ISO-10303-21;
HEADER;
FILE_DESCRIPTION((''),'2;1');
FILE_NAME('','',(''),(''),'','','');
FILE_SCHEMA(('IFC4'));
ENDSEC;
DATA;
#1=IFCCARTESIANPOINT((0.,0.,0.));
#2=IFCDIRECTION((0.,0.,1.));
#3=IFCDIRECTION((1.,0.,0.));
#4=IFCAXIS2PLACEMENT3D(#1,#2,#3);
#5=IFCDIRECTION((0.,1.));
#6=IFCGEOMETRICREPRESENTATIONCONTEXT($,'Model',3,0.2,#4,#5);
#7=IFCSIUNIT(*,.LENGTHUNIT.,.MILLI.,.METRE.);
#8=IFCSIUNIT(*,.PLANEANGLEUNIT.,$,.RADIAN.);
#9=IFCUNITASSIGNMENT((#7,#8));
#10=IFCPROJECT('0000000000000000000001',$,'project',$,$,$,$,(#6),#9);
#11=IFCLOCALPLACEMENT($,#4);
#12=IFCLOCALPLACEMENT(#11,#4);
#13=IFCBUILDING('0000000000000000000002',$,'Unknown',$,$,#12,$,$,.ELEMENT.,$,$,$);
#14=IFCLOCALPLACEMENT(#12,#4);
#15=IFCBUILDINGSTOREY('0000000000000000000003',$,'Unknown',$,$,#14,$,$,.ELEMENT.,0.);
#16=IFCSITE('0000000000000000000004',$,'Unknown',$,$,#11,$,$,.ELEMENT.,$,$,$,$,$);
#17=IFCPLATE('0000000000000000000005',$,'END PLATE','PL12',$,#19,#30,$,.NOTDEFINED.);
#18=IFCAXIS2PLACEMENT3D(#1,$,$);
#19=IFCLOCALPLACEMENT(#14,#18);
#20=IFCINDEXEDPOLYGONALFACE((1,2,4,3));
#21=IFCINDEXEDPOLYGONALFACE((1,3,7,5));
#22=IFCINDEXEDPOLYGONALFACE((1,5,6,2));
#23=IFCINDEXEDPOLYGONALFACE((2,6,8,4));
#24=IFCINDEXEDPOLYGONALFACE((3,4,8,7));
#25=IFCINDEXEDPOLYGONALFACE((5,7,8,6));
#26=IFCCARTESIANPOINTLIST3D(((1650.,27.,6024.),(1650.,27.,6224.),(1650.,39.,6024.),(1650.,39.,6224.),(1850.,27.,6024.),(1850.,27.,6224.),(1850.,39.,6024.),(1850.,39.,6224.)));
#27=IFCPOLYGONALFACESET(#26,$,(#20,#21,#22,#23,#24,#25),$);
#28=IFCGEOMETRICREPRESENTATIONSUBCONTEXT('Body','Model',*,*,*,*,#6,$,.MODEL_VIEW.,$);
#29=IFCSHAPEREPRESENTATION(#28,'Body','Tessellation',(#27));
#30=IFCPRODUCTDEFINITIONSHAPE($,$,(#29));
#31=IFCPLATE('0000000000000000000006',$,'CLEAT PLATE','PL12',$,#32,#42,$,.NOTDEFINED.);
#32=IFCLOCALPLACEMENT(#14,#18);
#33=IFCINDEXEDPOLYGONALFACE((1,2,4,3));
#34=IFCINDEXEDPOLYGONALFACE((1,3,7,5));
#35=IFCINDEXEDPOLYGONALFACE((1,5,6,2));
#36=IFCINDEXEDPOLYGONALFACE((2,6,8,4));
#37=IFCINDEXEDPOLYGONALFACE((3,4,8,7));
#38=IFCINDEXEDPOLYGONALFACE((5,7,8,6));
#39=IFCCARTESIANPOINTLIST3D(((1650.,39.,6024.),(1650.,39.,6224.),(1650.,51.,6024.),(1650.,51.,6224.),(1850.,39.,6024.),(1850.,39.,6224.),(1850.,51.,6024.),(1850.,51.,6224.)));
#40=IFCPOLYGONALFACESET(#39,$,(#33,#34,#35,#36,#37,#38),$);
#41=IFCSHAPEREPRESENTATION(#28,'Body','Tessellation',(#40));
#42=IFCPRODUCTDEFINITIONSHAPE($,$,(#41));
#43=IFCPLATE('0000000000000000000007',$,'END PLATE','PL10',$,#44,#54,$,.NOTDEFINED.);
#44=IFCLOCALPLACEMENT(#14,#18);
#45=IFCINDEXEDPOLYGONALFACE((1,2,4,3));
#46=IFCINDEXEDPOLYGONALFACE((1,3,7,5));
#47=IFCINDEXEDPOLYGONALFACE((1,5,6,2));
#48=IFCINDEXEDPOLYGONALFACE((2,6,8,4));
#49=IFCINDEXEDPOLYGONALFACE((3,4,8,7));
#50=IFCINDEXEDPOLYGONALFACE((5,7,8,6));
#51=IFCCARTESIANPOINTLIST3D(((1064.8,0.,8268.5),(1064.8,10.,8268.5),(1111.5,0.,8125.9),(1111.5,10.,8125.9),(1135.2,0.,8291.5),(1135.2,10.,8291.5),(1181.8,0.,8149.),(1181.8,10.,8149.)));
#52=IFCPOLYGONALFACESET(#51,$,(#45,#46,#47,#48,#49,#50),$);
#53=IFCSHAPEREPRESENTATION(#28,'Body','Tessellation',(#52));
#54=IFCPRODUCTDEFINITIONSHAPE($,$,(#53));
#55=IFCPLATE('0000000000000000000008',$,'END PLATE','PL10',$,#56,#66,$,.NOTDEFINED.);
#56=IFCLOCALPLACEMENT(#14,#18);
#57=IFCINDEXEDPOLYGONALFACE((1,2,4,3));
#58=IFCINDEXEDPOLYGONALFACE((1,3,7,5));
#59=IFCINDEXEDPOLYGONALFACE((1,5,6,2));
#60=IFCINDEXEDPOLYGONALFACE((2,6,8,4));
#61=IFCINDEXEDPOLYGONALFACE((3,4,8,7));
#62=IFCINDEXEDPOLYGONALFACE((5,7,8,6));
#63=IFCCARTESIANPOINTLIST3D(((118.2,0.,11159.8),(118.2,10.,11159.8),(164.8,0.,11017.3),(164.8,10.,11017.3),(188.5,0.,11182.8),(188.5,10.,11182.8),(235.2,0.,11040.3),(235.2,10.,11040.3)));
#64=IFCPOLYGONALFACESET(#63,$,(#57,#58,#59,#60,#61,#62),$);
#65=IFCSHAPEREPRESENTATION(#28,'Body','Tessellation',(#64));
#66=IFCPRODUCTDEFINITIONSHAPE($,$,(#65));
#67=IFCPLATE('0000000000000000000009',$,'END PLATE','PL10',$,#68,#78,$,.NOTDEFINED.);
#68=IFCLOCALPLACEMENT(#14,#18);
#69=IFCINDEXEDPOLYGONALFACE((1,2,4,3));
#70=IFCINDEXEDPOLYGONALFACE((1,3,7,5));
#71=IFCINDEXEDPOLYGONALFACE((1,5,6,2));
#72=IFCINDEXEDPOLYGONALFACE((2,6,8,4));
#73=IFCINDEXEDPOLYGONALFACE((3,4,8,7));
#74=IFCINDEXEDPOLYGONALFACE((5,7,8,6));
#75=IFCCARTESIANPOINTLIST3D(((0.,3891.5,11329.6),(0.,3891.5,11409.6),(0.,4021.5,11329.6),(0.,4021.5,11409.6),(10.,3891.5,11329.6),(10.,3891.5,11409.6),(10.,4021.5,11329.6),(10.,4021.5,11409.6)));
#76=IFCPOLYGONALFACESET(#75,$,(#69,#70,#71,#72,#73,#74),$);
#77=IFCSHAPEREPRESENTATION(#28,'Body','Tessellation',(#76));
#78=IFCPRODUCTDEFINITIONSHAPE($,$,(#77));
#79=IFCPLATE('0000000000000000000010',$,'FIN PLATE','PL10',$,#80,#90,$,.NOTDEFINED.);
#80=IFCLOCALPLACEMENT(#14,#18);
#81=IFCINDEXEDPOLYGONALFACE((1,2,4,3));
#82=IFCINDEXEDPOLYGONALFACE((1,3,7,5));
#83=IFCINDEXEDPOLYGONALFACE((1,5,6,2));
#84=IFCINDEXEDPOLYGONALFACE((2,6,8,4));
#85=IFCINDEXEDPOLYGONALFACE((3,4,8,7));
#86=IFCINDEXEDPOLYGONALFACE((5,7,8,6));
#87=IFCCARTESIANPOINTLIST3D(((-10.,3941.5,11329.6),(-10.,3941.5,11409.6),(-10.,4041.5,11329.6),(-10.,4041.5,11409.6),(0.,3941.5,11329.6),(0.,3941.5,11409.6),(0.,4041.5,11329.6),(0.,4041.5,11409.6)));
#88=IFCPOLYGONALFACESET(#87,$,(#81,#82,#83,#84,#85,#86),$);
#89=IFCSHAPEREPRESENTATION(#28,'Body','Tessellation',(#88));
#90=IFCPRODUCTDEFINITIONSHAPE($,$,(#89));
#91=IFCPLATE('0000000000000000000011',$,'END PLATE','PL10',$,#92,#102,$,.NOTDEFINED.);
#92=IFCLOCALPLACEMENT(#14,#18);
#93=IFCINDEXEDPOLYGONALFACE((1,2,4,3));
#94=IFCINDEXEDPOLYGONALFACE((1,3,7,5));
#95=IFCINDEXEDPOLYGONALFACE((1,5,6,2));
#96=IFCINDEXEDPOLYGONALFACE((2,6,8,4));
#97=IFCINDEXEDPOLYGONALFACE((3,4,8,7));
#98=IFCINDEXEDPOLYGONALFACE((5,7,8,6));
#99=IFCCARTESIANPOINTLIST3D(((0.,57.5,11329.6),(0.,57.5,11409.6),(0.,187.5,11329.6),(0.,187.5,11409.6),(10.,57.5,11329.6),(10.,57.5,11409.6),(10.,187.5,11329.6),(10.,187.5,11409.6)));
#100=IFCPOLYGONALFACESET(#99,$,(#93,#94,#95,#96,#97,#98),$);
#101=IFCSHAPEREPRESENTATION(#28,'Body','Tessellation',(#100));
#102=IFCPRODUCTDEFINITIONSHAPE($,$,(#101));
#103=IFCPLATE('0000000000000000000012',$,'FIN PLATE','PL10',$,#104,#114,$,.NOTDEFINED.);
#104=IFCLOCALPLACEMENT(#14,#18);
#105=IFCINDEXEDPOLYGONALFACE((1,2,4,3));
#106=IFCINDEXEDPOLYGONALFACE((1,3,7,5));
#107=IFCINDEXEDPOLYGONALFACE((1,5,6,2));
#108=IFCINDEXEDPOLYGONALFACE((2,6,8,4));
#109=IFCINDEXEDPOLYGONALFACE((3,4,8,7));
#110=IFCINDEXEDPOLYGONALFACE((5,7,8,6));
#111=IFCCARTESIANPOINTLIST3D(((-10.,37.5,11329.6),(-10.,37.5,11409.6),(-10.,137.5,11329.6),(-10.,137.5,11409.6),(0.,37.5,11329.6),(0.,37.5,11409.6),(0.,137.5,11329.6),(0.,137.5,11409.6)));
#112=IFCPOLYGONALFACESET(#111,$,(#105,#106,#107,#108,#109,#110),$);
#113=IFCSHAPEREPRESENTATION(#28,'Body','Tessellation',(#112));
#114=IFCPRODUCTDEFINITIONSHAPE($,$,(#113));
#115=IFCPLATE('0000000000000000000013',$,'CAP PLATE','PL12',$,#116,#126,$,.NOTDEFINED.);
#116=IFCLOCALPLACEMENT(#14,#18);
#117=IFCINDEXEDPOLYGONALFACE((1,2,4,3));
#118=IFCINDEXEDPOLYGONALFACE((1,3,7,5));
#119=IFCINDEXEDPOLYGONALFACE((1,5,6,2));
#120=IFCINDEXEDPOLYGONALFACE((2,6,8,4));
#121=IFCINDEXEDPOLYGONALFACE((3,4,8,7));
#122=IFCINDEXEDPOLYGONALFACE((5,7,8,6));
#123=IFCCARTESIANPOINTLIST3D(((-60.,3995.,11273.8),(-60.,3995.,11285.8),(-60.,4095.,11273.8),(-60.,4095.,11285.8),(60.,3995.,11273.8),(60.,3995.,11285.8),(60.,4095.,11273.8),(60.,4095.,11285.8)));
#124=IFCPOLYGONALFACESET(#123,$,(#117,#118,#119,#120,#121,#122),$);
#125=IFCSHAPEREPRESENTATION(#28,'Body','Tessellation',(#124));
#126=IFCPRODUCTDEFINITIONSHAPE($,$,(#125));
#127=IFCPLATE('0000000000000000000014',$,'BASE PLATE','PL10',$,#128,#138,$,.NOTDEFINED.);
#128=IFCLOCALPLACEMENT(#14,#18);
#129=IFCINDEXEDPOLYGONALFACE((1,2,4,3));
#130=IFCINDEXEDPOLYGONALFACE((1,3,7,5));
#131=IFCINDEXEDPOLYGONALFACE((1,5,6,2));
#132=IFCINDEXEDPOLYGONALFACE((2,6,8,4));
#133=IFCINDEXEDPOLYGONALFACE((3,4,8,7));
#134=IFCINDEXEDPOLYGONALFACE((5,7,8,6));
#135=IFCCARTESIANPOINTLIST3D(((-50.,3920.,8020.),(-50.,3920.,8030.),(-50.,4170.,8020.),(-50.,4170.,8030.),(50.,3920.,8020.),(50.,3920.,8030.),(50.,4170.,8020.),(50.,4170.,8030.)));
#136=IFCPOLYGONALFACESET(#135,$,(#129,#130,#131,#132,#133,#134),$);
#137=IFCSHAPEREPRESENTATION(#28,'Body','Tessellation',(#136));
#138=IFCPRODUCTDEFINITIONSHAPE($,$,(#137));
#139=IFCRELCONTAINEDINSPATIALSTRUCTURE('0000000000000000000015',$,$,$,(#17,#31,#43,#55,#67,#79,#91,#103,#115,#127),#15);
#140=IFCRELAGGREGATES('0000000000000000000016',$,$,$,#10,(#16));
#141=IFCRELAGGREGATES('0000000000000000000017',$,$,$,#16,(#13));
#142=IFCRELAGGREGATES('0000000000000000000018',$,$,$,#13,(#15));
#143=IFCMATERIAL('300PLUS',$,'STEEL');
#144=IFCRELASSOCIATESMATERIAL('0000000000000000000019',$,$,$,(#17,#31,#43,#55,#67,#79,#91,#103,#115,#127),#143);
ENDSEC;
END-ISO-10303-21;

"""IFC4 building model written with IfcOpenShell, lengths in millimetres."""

from ifc_helpers import new_model, si_unit, direction, frame, origin_with_axes, place, context, subcontext, project, spatial, line, indexed_curve, outline, extrude, material, element, save


model = new_model("IFC4")

# Units and contexts
model_context = context("Model", 3, precision=0.2, world=origin_with_axes(), true_north=direction((0.0, 1.0)))
body_context = subcontext(model_context, "Body", "Model", "MODEL_VIEW")
ifc_project = project(units=[si_unit("LENGTHUNIT", "METRE", prefix="MILLI"), si_unit("PLANEANGLEUNIT", "RADIAN")], contexts=[model_context])

# Site, building, storey
site_placement = place(None, origin_with_axes())
site = spatial("IfcSite", under=ifc_project, at=site_placement, Name="Unknown", CompositionType="ELEMENT")
building_placement = place(site_placement, origin_with_axes())
building = spatial("IfcBuilding", under=site, at=building_placement, Name="Unknown", CompositionType="ELEMENT")
storey_placement = place(building_placement, origin_with_axes())
storey = spatial("IfcBuildingStorey", under=building, at=storey_placement, Name="Unknown", CompositionType="ELEMENT", Elevation=0.0)

# Shared definitions
ifc_material_1 = material(Name="300PLUS", Category="STEEL")

# Plates
for number, where, z_axis, x_axis, name in (
    (1, (1650.0, 33.0, 6224.0), (0.0, 1.0, 0.0), (1.0, 0.0, 0.0), "END PLATE"),
    (2, (1650.0, 45.0, 6224.0), (0.0, 1.0, 0.0), (1.0, 0.0, 0.0), "CLEAT PLATE"),
):
    element("IfcPlate", number, at=place(storey_placement, frame(where, z_axis=z_axis, x_axis=x_axis)), inside=storey, material=ifc_material_1, Name=name, Description="PL12", PredefinedType="NOTDEFINED", context=body_context, shape_type="SolidModel", body=[
        extrude(outline(indexed_curve([(0.0, 0.0), (200.0, 0.0), (200.0, 200.0), (0.0, 200.0)], segments=[line(1, 2, 3, 4, 1)])), frame((0.0, 0.0, 6.0), z_axis=(0.0, 0.0, 1.0), x_axis=(1.0, 0.0, 0.0)), (0.0, 0.0, -1.0), 12.0),
    ])
plate_1_placement = place(storey_placement, frame((1064.8, 5.0, 8268.5), z_axis=(0.0, 1.0, 0.0), x_axis=(0.950557, 0.0, 0.310551)))
element("IfcPlate", 3, at=plate_1_placement, inside=storey, material=ifc_material_1, Name="END PLATE", Description="PL10", PredefinedType="NOTDEFINED", context=body_context, shape_type="SolidModel", body=[
    extrude(outline(indexed_curve([(0.0, 0.0), (74.1, 0.0), (74.1, 149.9), (0.1, 150.1)], segments=[line(1, 2, 3, 4, 1)])), frame((0.0, 0.0, 5.0), z_axis=(0.0, 0.0, 1.0), x_axis=(1.0, 0.0, 0.0)), (0.0, 0.0, -1.0), 10.0),
])
plate_2_placement = place(storey_placement, frame((118.2, 5.0, 11159.8), z_axis=(0.0, 1.0, 0.0), x_axis=(0.950426, 0.0, 0.31095)))
element("IfcPlate", 4, at=plate_2_placement, inside=storey, material=ifc_material_1, Name="END PLATE", Description="PL10", PredefinedType="NOTDEFINED", context=body_context, shape_type="SolidModel", body=[
    extrude(outline(indexed_curve([(0.0, 0.0), (74.0, 0.0), (74.0, 150.0), (0.0, 149.9)], segments=[line(1, 2, 3, 4, 1)])), frame((0.0, 0.0, 5.0), z_axis=(0.0, 0.0, 1.0), x_axis=(1.0, 0.0, 0.0)), (0.0, 0.0, -1.0), 10.0),
])
plate_3_placement = place(storey_placement, frame((5.0, 3891.5, 11329.6), z_axis=(1.0, 0.0, 0.0), x_axis=(0.0, 1.0, 0.0)))
element("IfcPlate", 5, at=plate_3_placement, inside=storey, material=ifc_material_1, Name="END PLATE", Description="PL10", PredefinedType="NOTDEFINED", context=body_context, shape_type="SolidModel", body=[
    extrude(outline(indexed_curve([(0.0, 0.0), (130.0, 0.0), (130.0, 80.0), (0.0, 80.0)], segments=[line(1, 2, 3, 4, 1)])), frame((0.0, 0.0, 5.0), z_axis=(0.0, 0.0, 1.0), x_axis=(1.0, 0.0, 0.0)), (0.0, 0.0, -1.0), 10.0),
])
plate_4_placement = place(storey_placement, frame((-5.0, 4041.5, 11329.6), z_axis=(-1.0, 0.0, 0.0), x_axis=(0.0, -1.0, 0.0)))
element("IfcPlate", 6, at=plate_4_placement, inside=storey, material=ifc_material_1, Name="FIN PLATE", Description="PL10", PredefinedType="NOTDEFINED", context=body_context, shape_type="SolidModel", body=[
    extrude(outline(indexed_curve([(0.0, 0.0), (100.0, 0.0), (100.0, 80.0), (0.0, 80.0)], segments=[line(1, 2, 3, 4, 1)])), frame((0.0, 0.0, 5.0), z_axis=(0.0, 0.0, 1.0), x_axis=(1.0, 0.0, 0.0)), (0.0, 0.0, -1.0), 10.0),
])
plate_5_placement = place(storey_placement, frame((5.0, 187.5, 11409.6), z_axis=(1.0, 0.0, 0.0), x_axis=(0.0, -1.0, 0.0)))
element("IfcPlate", 7, at=plate_5_placement, inside=storey, material=ifc_material_1, Name="END PLATE", Description="PL10", PredefinedType="NOTDEFINED", context=body_context, shape_type="SolidModel", body=[
    extrude(outline(indexed_curve([(0.0, 0.0), (130.0, 0.0), (130.0, 80.0), (0.0, 80.0)], segments=[line(1, 2, 3, 4, 1)])), frame((0.0, 0.0, 5.0), z_axis=(0.0, 0.0, 1.0), x_axis=(1.0, 0.0, 0.0)), (0.0, 0.0, -1.0), 10.0),
])
plate_6_placement = place(storey_placement, frame((-5.0, 37.5, 11409.6), z_axis=(-1.0, 0.0, 0.0), x_axis=(0.0, 1.0, 0.0)))
element("IfcPlate", 8, at=plate_6_placement, inside=storey, material=ifc_material_1, Name="FIN PLATE", Description="PL10", PredefinedType="NOTDEFINED", context=body_context, shape_type="SolidModel", body=[
    extrude(outline(indexed_curve([(0.0, 0.0), (100.0, 0.0), (100.0, 80.0), (0.0, 80.0)], segments=[line(1, 2, 3, 4, 1)])), frame((0.0, 0.0, 5.0), z_axis=(0.0, 0.0, 1.0), x_axis=(1.0, 0.0, 0.0)), (0.0, 0.0, -1.0), 10.0),
])
plate_7_placement = place(storey_placement, frame((-60.0, 3995.0, 11279.8), z_axis=(0.0, 0.0, 1.0), x_axis=(1.0, 0.0, 0.0)))
element("IfcPlate", 9, at=plate_7_placement, inside=storey, material=ifc_material_1, Name="CAP PLATE", Description="PL12", PredefinedType="NOTDEFINED", context=body_context, shape_type="SolidModel", body=[
    extrude(outline(indexed_curve([(0.0, 0.0), (120.0, 0.0), (120.0, 100.0), (0.0, 100.0)], segments=[line(1, 2, 3, 4, 1)])), frame((0.0, 0.0, 6.0), z_axis=(0.0, 0.0, 1.0), x_axis=(1.0, 0.0, 0.0)), (0.0, 0.0, -1.0), 12.0),
])
plate_8_placement = place(storey_placement, frame((-50.0, 3920.0, 8025.0), z_axis=(0.0, 0.0, 1.0), x_axis=(1.0, 0.0, 0.0)))
element("IfcPlate", 10, at=plate_8_placement, inside=storey, material=ifc_material_1, Name="BASE PLATE", Description="PL10", PredefinedType="NOTDEFINED", context=body_context, shape_type="SolidModel", body=[
    extrude(outline(indexed_curve([(0.0, 0.0), (100.0, 0.0), (100.0, 250.0), (0.0, 250.0)], segments=[line(1, 2, 3, 4, 1)])), frame((0.0, 0.0, 5.0), z_axis=(0.0, 0.0, 1.0), x_axis=(1.0, 0.0, 0.0)), (0.0, 0.0, -1.0), 10.0),
])

save(model, "model.ifc")
